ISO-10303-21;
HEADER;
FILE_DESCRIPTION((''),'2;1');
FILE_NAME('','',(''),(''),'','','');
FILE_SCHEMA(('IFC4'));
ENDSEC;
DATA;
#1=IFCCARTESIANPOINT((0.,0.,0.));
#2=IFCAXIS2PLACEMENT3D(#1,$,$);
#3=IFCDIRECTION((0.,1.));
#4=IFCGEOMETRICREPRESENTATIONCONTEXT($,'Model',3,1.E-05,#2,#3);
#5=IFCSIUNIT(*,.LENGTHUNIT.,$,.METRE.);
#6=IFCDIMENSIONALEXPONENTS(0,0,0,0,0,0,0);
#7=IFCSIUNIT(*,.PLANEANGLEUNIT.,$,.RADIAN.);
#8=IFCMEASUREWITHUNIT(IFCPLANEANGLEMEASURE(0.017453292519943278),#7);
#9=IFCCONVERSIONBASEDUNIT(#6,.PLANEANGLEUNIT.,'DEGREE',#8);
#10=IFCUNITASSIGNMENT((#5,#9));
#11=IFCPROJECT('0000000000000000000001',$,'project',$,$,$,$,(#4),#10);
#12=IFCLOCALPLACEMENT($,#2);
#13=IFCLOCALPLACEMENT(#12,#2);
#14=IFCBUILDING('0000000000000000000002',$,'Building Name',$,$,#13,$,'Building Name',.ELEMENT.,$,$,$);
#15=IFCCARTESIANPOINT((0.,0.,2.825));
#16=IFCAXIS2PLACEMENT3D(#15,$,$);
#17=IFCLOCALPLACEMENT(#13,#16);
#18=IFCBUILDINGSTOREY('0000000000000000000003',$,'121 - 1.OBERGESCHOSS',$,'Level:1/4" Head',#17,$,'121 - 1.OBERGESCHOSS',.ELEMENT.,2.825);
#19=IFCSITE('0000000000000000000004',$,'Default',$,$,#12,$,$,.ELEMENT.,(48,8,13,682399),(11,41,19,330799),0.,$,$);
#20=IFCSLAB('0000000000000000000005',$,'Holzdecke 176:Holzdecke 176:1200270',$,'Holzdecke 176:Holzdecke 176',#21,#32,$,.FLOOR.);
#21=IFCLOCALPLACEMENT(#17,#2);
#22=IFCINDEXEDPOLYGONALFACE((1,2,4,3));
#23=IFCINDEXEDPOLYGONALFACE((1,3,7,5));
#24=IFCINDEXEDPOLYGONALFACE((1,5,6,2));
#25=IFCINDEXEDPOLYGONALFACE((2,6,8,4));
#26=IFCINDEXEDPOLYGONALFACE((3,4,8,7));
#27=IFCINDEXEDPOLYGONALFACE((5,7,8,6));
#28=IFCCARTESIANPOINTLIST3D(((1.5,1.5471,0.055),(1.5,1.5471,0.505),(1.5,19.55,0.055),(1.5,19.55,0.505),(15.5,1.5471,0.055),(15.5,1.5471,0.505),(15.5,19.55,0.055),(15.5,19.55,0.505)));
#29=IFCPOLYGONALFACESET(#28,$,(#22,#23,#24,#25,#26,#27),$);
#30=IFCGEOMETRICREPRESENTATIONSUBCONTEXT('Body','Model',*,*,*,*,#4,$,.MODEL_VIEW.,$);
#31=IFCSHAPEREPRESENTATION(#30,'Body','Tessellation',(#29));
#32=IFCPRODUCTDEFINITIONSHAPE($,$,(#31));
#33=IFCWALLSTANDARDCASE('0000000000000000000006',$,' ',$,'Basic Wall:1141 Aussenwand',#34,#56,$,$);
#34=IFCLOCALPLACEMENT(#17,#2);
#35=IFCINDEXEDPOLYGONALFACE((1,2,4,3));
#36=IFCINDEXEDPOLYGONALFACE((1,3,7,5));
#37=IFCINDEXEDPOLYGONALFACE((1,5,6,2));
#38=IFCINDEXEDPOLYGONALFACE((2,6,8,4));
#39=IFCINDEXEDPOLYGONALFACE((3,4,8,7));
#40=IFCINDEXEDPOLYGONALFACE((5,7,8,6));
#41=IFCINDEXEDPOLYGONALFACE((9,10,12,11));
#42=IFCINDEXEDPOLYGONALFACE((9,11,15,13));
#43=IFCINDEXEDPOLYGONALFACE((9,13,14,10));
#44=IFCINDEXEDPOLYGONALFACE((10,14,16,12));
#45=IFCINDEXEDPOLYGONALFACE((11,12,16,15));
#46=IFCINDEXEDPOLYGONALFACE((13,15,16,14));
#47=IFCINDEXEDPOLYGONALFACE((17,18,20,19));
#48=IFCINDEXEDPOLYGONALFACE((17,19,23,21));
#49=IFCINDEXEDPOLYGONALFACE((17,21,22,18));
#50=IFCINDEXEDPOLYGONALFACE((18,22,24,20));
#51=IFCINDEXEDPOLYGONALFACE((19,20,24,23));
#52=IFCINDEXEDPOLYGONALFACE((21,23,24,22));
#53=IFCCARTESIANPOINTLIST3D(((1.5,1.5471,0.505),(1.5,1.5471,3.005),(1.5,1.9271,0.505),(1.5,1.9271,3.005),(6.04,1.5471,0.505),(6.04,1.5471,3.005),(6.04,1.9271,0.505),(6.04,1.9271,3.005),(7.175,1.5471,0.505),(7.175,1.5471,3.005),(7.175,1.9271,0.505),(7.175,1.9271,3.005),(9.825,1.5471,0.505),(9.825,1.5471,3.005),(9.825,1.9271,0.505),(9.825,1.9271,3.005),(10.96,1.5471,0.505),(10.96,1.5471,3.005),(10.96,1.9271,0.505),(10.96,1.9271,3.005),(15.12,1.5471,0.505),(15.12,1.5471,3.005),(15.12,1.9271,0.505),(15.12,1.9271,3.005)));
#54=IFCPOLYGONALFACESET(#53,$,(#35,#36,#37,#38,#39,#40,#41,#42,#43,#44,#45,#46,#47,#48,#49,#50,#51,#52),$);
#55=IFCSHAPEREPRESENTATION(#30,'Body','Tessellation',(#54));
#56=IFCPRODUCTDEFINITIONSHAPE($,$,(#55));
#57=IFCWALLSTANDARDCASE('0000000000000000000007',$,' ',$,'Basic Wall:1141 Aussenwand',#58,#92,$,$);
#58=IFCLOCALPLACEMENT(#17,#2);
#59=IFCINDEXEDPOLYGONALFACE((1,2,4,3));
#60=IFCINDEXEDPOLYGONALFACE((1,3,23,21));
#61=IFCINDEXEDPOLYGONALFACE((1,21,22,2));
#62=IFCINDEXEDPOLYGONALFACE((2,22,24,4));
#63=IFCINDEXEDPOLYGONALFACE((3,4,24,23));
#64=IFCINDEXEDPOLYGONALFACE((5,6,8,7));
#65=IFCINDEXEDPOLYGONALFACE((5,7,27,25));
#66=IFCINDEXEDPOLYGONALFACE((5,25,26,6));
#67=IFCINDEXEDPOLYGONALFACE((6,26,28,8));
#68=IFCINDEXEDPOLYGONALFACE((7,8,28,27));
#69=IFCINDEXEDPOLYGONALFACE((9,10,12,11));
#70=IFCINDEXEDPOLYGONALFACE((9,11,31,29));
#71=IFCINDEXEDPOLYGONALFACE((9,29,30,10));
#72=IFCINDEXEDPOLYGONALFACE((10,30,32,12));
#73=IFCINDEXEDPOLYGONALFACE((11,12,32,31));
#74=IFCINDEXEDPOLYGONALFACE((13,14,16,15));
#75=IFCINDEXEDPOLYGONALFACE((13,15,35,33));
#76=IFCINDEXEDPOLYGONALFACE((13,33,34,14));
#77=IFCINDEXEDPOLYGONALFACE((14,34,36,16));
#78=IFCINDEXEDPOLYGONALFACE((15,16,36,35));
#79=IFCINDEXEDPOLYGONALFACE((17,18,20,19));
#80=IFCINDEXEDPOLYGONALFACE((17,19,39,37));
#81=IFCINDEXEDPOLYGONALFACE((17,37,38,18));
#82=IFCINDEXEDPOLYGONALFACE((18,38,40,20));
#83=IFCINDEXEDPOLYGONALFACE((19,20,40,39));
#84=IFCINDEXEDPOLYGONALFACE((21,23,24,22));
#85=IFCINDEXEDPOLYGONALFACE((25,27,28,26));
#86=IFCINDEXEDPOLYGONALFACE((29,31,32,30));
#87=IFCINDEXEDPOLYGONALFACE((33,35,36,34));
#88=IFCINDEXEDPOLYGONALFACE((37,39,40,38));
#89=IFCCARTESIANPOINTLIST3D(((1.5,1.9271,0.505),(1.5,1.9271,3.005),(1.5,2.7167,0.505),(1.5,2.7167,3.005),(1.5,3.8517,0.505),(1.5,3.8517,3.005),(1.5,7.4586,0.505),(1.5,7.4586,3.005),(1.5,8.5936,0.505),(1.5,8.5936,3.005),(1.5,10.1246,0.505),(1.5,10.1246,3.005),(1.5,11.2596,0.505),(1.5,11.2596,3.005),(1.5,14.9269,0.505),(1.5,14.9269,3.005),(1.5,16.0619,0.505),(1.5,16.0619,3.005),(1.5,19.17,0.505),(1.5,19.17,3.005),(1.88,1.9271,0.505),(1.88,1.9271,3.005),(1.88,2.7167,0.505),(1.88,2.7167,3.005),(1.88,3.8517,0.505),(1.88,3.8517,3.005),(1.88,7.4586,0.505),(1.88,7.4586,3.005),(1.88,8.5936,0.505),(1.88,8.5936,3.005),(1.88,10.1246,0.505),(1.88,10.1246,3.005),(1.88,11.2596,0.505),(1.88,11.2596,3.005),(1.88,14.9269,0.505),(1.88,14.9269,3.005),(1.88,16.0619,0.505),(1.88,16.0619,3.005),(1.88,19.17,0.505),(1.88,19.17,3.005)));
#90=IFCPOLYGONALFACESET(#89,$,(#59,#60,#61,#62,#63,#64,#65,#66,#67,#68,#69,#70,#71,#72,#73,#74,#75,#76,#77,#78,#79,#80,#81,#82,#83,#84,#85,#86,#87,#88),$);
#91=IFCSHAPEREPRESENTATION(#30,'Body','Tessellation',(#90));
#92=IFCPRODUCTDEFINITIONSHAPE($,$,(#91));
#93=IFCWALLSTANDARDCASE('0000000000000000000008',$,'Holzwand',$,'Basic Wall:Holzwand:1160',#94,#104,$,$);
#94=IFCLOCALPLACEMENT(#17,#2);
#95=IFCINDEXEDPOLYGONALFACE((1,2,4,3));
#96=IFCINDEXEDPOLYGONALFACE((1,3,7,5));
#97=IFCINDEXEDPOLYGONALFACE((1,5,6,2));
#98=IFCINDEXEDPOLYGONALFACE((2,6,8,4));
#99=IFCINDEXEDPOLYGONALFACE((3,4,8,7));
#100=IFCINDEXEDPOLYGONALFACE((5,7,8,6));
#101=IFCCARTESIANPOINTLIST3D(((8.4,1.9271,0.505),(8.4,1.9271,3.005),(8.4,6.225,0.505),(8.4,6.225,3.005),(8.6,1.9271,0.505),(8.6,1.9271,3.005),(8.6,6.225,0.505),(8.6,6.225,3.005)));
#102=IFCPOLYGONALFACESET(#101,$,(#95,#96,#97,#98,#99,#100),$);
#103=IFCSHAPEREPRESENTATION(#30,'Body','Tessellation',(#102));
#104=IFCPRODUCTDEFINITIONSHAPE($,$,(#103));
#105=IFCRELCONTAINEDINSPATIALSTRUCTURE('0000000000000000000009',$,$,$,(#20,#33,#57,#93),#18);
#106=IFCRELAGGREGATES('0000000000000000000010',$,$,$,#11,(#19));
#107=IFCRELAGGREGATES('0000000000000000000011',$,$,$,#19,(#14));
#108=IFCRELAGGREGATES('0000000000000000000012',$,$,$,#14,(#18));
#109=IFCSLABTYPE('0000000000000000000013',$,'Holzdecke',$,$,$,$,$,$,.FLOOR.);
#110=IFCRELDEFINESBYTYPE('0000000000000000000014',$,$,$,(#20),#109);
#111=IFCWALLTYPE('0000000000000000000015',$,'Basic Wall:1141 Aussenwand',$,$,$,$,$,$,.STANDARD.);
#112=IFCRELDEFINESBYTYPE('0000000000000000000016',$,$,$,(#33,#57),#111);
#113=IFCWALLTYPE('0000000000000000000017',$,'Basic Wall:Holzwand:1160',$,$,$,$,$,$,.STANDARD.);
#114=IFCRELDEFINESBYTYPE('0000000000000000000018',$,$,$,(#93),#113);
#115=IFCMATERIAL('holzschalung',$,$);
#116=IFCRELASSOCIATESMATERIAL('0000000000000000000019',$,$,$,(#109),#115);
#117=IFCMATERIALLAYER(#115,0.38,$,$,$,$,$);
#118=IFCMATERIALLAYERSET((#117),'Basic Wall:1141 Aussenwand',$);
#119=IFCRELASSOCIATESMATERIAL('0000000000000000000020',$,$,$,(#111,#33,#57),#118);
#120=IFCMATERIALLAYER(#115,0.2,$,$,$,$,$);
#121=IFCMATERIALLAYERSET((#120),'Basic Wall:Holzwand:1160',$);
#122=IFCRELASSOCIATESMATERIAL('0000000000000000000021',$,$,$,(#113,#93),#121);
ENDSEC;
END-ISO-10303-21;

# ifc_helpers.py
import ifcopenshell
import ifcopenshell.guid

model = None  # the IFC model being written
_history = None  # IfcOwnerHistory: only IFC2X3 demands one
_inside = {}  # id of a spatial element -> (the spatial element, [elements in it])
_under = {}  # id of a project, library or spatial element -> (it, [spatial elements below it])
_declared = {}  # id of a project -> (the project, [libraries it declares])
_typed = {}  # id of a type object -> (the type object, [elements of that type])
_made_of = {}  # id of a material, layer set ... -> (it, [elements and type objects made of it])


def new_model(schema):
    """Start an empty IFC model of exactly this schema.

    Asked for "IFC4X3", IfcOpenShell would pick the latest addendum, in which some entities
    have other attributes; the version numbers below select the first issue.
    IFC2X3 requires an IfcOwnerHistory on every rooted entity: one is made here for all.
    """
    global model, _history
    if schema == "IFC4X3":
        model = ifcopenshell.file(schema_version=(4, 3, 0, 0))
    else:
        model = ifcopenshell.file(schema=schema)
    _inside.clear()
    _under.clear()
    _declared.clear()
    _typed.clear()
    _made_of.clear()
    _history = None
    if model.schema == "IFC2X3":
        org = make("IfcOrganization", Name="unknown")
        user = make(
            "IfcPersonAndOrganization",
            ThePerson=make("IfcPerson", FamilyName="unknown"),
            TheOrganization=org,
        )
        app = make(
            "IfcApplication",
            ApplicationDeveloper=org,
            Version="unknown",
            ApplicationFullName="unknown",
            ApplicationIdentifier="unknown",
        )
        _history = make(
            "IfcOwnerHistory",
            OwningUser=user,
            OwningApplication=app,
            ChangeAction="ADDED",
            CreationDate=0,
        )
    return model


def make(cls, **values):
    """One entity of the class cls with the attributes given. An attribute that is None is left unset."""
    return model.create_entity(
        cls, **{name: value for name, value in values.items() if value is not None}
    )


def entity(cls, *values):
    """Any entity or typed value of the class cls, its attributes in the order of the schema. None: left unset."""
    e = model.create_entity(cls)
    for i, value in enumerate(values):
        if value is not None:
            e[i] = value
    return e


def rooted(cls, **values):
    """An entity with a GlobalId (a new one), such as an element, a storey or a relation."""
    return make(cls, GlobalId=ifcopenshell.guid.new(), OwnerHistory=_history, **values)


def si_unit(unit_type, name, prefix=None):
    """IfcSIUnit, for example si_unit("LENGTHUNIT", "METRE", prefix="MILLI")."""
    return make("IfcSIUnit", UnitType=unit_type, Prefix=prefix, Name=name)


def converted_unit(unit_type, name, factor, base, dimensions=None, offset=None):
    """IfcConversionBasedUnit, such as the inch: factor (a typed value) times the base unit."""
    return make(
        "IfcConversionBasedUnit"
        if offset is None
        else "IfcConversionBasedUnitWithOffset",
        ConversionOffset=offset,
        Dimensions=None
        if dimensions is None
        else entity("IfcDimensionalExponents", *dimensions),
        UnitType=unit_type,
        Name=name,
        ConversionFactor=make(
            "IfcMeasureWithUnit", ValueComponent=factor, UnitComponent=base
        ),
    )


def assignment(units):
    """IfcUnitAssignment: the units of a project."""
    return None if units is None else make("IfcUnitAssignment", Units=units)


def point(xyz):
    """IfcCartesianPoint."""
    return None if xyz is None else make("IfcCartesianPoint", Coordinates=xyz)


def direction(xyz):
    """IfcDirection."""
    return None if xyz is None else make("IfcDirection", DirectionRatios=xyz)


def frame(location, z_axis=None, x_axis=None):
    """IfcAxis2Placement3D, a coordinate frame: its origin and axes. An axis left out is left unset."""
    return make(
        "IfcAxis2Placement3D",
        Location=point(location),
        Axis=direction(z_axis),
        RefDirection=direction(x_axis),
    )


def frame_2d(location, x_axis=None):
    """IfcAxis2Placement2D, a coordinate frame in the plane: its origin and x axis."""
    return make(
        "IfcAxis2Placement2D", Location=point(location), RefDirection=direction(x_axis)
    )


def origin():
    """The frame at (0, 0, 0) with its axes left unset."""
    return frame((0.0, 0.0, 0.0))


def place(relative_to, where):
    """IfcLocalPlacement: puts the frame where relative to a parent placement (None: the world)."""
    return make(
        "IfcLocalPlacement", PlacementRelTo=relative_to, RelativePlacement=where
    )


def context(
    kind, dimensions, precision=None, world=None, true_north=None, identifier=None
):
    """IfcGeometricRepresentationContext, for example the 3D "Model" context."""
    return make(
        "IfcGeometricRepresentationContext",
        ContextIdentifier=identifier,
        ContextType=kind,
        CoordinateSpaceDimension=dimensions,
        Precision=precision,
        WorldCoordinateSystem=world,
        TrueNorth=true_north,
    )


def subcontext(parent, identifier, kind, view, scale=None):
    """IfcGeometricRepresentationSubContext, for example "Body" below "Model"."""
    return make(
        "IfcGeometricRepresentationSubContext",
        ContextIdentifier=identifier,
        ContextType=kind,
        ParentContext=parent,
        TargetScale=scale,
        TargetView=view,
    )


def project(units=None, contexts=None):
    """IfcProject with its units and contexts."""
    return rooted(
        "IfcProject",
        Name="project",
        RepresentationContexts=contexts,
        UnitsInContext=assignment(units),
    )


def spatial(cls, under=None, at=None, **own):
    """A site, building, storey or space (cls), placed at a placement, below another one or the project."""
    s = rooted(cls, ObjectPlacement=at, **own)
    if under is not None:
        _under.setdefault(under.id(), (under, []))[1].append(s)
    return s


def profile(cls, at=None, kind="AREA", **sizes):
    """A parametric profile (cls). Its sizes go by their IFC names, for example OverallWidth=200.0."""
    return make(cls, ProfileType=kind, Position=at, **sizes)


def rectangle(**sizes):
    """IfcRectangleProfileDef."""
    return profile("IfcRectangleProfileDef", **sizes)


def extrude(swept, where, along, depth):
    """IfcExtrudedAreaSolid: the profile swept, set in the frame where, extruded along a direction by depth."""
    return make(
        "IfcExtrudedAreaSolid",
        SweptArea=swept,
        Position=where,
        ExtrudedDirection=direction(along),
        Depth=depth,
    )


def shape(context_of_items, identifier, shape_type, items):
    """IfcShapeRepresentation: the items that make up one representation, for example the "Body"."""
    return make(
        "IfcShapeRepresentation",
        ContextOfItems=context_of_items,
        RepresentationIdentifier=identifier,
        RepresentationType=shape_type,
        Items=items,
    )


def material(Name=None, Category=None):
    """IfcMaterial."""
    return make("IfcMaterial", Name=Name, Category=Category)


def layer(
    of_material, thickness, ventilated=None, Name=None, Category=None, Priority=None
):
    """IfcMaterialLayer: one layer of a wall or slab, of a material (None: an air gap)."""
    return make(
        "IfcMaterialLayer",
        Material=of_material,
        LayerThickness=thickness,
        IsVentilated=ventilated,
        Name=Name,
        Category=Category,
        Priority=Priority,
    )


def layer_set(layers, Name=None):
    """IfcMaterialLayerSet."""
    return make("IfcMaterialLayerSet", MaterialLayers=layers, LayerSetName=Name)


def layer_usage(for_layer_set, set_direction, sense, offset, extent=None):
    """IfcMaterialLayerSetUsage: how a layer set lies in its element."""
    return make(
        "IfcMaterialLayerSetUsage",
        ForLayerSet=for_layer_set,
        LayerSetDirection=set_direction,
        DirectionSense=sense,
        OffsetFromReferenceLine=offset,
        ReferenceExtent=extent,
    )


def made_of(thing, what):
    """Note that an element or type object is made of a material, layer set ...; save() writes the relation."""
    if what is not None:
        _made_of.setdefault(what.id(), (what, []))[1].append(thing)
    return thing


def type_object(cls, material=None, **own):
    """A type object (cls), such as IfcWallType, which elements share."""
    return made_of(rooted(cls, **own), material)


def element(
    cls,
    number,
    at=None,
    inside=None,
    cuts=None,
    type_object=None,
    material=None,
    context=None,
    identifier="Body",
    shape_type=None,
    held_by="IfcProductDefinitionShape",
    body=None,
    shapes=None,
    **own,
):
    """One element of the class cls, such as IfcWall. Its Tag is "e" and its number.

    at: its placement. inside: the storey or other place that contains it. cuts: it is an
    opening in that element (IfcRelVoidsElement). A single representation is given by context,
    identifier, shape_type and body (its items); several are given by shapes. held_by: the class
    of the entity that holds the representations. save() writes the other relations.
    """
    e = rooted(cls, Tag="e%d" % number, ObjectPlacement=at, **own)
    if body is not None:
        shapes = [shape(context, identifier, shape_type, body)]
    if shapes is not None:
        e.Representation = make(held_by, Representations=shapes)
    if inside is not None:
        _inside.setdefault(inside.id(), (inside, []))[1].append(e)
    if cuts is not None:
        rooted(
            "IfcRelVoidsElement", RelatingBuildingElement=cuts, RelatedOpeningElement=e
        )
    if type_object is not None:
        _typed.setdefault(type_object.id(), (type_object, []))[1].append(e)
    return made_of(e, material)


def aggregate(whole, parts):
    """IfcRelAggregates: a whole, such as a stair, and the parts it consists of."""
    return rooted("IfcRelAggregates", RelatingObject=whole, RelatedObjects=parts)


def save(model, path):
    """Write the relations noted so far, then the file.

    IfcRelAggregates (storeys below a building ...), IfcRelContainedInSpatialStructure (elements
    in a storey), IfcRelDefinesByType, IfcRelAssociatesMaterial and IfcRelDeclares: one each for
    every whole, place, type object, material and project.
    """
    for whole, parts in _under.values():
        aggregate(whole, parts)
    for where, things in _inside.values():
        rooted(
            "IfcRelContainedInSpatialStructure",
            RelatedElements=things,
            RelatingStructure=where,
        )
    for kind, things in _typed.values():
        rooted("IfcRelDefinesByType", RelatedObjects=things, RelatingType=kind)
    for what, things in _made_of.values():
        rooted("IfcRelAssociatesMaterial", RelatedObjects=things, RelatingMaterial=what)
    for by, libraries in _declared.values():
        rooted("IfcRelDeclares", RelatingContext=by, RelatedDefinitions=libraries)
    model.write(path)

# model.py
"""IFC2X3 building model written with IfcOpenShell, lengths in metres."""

from ifc_helpers import new_model, entity, si_unit, converted_unit, direction, frame, frame_2d, origin, place, context, subcontext, project, spatial, rectangle, extrude, material, layer, layer_set, layer_usage, type_object, element, save


model = new_model("IFC2X3")

# Units and contexts
model_context = context("Model", 3, precision=1e-05, world=origin(), true_north=direction((0.0, 1.0)))
body_context = subcontext(model_context, "Body", "Model", "MODEL_VIEW")
ifc_project = project(units=[si_unit("LENGTHUNIT", "METRE"), converted_unit("PLANEANGLEUNIT", "DEGREE", entity("IfcPlaneAngleMeasure", 0.017453292519943278), si_unit("PLANEANGLEUNIT", "RADIAN"), dimensions=[0, 0, 0, 0, 0, 0, 0])], contexts=[model_context])

# Site, building, storey
site_placement = place(None, origin())
site = spatial("IfcSite", under=ifc_project, at=site_placement, Name="Default", CompositionType="ELEMENT", RefLatitude=(48, 8, 13, 682399), RefLongitude=(11, 41, 19, 330799), RefElevation=0.0)
building_placement = place(site_placement, origin())
building = spatial("IfcBuilding", under=site, at=building_placement, Name="Building Name", LongName="Building Name", CompositionType="ELEMENT")
storey_placement = place(building_placement, frame((0.0, 0.0, 2.825)))
storey = spatial("IfcBuildingStorey", under=building, at=storey_placement, Name="121 - 1.OBERGESCHOSS", ObjectType="Level:1/4\" Head", LongName="121 - 1.OBERGESCHOSS", CompositionType="ELEMENT", Elevation=2.825)

# Slab
ifc_material_1 = material(Name="holzschalung")
slab_type = type_object("IfcSlabType", Name="Holzdecke", PredefinedType="FLOOR", material=ifc_material_1)
slab_placement = place(storey_placement, origin())
element("IfcSlab", 1, at=slab_placement, inside=storey, type_object=slab_type, Name="Holzdecke 176:Holzdecke 176:1200270", ObjectType="Holzdecke 176:Holzdecke 176", PredefinedType="FLOOR", context=body_context, shape_type="SweptSolid", body=[
    extrude(rectangle(XDim=14.0, YDim=18.0029, at=frame_2d((0.0, 0.0), x_axis=(1.0, 0.0))), frame((8.5, 10.5486, 0.055), z_axis=(0.0, 0.0, 1.0), x_axis=(-1.0, 0.0, 0.0)), (0.0, 0.0, 1.0), 0.45),
])

# Walls, openings
ifc_layer_1 = layer(ifc_material_1, 0.38)
ifc_layer_set_1 = layer_set([ifc_layer_1], Name="Basic Wall:1141 Aussenwand")
ifc_layer_usage_1 = layer_usage(ifc_layer_set_1, "AXIS2", "NEGATIVE", 0.19)
wall_type_1 = type_object("IfcWallType", Name="Basic Wall:1141 Aussenwand", PredefinedType="STANDARD", material=ifc_layer_set_1)
wall_1_placement = place(storey_placement, frame((15.12, 1.7371, 0.505), z_axis=(0.0, 0.0, 1.0), x_axis=(-1.0, 0.0, 0.0)))
wall_1 = element("IfcWallStandardCase", 2, at=wall_1_placement, inside=storey, type_object=wall_type_1, material=ifc_layer_usage_1, Name=" ", ObjectType="Basic Wall:1141 Aussenwand", context=body_context, shape_type="SweptSolid", body=[
    extrude(rectangle(XDim=13.62, YDim=0.38, at=frame_2d((6.81, 0.0), x_axis=(-1.0, 0.0))), origin(), (0.0, 0.0, 1.0), 2.5),
])
opening_1_placement = place(wall_1_placement, origin())
element("IfcOpeningElement", 3, at=opening_1_placement, cuts=wall_1, ObjectType="Opening", context=body_context, shape_type="SweptSolid", body=[
    extrude(rectangle(XDim=2.5, YDim=1.135, at=frame_2d((0.0, 0.0), x_axis=(1.0, 0.0))), frame((4.7275, -0.19, 1.25), z_axis=(0.0, 1.0, 0.0), x_axis=(0.0, 0.0, 1.0)), (0.0, 0.0, 1.0), 0.38),
])
opening_2_placement = place(wall_1_placement, origin())
element("IfcOpeningElement", 4, at=opening_2_placement, cuts=wall_1, ObjectType="Opening", context=body_context, shape_type="SweptSolid", body=[
    extrude(rectangle(XDim=2.5, YDim=1.135, at=frame_2d((0.0, 0.0), x_axis=(1.0, 0.0))), frame((8.5125, -0.19, 1.25), z_axis=(0.0, 1.0, 0.0), x_axis=(0.0, 0.0, 1.0)), (0.0, 0.0, 1.0), 0.38),
])
ifc_layer_usage_2 = layer_usage(ifc_layer_set_1, "AXIS2", "NEGATIVE", 0.19)
wall_2_placement = place(storey_placement, frame((1.69, 1.9271, 0.505), z_axis=(0.0, 0.0, 1.0), x_axis=(0.0, 1.0, 0.0)))
wall_2 = element("IfcWallStandardCase", 5, at=wall_2_placement, inside=storey, type_object=wall_type_1, material=ifc_layer_usage_2, Name=" ", ObjectType="Basic Wall:1141 Aussenwand", context=body_context, shape_type="SweptSolid", body=[
    extrude(rectangle(XDim=17.2429, YDim=0.38, at=frame_2d((8.6214, 0.0), x_axis=(-1.0, 0.0))), origin(), (0.0, 0.0, 1.0), 2.5),
])
opening_3_placement = place(wall_2_placement, origin())
element("IfcOpeningElement", 6, at=opening_3_placement, cuts=wall_2, ObjectType="Opening", context=body_context, shape_type="SweptSolid", body=[
    extrude(rectangle(XDim=2.5, YDim=1.135, at=frame_2d((0.0, 0.0), x_axis=(1.0, 0.0))), frame((13.5673, -0.19, 1.25), z_axis=(0.0, 1.0, 0.0), x_axis=(0.0, 0.0, 1.0)), (0.0, 0.0, 1.0), 0.38),
])
opening_4_placement = place(wall_2_placement, origin())
element("IfcOpeningElement", 7, at=opening_4_placement, cuts=wall_2, ObjectType="Opening", context=body_context, shape_type="SweptSolid", body=[
    extrude(rectangle(XDim=2.5, YDim=1.135, at=frame_2d((0.0, 0.0), x_axis=(1.0, 0.0))), frame((8.765, -0.19, 1.25), z_axis=(0.0, 1.0, 0.0), x_axis=(0.0, 0.0, 1.0)), (0.0, 0.0, 1.0), 0.38),
])
opening_5_placement = place(wall_2_placement, origin())
element("IfcOpeningElement", 8, at=opening_5_placement, cuts=wall_2, ObjectType="Opening", context=body_context, shape_type="SweptSolid", body=[
    extrude(rectangle(XDim=2.5, YDim=1.135, at=frame_2d((0.0, 0.0), x_axis=(1.0, 0.0))), frame((6.0989, -0.19, 1.25), z_axis=(0.0, 1.0, 0.0), x_axis=(0.0, 0.0, 1.0)), (0.0, 0.0, 1.0), 0.38),
])
opening_6_placement = place(wall_2_placement, origin())
element("IfcOpeningElement", 9, at=opening_6_placement, cuts=wall_2, ObjectType="Opening", context=body_context, shape_type="SweptSolid", body=[
    extrude(rectangle(XDim=2.5, YDim=1.135, at=frame_2d((0.0, 0.0), x_axis=(1.0, 0.0))), frame((1.3571, -0.19, 1.25), z_axis=(0.0, 1.0, 0.0), x_axis=(0.0, 0.0, 1.0)), (0.0, 0.0, 1.0), 0.38),
])

# Wall
ifc_layer_2 = layer(ifc_material_1, 0.2)
ifc_layer_set_2 = layer_set([ifc_layer_2], Name="Basic Wall:Holzwand:1160")
ifc_layer_usage_3 = layer_usage(ifc_layer_set_2, "AXIS2", "NEGATIVE", 0.1)
wall_type_2 = type_object("IfcWallType", Name="Basic Wall:Holzwand:1160", PredefinedType="STANDARD", material=ifc_layer_set_2)
wall_3_placement = place(storey_placement, frame((8.5, 1.9271, 0.505), z_axis=(0.0, 0.0, 1.0), x_axis=(0.0, 1.0, 0.0)))
element("IfcWallStandardCase", 10, at=wall_3_placement, inside=storey, type_object=wall_type_2, material=ifc_layer_usage_3, Name="Holzwand", ObjectType="Basic Wall:Holzwand:1160", context=body_context, shape_type="SweptSolid", body=[
    extrude(rectangle(XDim=4.2979, YDim=0.2, at=frame_2d((2.1489, 0.0), x_axis=(-1.0, 0.0))), origin(), (0.0, 0.0, 1.0), 2.5),
])

save(model, "model.ifc")
